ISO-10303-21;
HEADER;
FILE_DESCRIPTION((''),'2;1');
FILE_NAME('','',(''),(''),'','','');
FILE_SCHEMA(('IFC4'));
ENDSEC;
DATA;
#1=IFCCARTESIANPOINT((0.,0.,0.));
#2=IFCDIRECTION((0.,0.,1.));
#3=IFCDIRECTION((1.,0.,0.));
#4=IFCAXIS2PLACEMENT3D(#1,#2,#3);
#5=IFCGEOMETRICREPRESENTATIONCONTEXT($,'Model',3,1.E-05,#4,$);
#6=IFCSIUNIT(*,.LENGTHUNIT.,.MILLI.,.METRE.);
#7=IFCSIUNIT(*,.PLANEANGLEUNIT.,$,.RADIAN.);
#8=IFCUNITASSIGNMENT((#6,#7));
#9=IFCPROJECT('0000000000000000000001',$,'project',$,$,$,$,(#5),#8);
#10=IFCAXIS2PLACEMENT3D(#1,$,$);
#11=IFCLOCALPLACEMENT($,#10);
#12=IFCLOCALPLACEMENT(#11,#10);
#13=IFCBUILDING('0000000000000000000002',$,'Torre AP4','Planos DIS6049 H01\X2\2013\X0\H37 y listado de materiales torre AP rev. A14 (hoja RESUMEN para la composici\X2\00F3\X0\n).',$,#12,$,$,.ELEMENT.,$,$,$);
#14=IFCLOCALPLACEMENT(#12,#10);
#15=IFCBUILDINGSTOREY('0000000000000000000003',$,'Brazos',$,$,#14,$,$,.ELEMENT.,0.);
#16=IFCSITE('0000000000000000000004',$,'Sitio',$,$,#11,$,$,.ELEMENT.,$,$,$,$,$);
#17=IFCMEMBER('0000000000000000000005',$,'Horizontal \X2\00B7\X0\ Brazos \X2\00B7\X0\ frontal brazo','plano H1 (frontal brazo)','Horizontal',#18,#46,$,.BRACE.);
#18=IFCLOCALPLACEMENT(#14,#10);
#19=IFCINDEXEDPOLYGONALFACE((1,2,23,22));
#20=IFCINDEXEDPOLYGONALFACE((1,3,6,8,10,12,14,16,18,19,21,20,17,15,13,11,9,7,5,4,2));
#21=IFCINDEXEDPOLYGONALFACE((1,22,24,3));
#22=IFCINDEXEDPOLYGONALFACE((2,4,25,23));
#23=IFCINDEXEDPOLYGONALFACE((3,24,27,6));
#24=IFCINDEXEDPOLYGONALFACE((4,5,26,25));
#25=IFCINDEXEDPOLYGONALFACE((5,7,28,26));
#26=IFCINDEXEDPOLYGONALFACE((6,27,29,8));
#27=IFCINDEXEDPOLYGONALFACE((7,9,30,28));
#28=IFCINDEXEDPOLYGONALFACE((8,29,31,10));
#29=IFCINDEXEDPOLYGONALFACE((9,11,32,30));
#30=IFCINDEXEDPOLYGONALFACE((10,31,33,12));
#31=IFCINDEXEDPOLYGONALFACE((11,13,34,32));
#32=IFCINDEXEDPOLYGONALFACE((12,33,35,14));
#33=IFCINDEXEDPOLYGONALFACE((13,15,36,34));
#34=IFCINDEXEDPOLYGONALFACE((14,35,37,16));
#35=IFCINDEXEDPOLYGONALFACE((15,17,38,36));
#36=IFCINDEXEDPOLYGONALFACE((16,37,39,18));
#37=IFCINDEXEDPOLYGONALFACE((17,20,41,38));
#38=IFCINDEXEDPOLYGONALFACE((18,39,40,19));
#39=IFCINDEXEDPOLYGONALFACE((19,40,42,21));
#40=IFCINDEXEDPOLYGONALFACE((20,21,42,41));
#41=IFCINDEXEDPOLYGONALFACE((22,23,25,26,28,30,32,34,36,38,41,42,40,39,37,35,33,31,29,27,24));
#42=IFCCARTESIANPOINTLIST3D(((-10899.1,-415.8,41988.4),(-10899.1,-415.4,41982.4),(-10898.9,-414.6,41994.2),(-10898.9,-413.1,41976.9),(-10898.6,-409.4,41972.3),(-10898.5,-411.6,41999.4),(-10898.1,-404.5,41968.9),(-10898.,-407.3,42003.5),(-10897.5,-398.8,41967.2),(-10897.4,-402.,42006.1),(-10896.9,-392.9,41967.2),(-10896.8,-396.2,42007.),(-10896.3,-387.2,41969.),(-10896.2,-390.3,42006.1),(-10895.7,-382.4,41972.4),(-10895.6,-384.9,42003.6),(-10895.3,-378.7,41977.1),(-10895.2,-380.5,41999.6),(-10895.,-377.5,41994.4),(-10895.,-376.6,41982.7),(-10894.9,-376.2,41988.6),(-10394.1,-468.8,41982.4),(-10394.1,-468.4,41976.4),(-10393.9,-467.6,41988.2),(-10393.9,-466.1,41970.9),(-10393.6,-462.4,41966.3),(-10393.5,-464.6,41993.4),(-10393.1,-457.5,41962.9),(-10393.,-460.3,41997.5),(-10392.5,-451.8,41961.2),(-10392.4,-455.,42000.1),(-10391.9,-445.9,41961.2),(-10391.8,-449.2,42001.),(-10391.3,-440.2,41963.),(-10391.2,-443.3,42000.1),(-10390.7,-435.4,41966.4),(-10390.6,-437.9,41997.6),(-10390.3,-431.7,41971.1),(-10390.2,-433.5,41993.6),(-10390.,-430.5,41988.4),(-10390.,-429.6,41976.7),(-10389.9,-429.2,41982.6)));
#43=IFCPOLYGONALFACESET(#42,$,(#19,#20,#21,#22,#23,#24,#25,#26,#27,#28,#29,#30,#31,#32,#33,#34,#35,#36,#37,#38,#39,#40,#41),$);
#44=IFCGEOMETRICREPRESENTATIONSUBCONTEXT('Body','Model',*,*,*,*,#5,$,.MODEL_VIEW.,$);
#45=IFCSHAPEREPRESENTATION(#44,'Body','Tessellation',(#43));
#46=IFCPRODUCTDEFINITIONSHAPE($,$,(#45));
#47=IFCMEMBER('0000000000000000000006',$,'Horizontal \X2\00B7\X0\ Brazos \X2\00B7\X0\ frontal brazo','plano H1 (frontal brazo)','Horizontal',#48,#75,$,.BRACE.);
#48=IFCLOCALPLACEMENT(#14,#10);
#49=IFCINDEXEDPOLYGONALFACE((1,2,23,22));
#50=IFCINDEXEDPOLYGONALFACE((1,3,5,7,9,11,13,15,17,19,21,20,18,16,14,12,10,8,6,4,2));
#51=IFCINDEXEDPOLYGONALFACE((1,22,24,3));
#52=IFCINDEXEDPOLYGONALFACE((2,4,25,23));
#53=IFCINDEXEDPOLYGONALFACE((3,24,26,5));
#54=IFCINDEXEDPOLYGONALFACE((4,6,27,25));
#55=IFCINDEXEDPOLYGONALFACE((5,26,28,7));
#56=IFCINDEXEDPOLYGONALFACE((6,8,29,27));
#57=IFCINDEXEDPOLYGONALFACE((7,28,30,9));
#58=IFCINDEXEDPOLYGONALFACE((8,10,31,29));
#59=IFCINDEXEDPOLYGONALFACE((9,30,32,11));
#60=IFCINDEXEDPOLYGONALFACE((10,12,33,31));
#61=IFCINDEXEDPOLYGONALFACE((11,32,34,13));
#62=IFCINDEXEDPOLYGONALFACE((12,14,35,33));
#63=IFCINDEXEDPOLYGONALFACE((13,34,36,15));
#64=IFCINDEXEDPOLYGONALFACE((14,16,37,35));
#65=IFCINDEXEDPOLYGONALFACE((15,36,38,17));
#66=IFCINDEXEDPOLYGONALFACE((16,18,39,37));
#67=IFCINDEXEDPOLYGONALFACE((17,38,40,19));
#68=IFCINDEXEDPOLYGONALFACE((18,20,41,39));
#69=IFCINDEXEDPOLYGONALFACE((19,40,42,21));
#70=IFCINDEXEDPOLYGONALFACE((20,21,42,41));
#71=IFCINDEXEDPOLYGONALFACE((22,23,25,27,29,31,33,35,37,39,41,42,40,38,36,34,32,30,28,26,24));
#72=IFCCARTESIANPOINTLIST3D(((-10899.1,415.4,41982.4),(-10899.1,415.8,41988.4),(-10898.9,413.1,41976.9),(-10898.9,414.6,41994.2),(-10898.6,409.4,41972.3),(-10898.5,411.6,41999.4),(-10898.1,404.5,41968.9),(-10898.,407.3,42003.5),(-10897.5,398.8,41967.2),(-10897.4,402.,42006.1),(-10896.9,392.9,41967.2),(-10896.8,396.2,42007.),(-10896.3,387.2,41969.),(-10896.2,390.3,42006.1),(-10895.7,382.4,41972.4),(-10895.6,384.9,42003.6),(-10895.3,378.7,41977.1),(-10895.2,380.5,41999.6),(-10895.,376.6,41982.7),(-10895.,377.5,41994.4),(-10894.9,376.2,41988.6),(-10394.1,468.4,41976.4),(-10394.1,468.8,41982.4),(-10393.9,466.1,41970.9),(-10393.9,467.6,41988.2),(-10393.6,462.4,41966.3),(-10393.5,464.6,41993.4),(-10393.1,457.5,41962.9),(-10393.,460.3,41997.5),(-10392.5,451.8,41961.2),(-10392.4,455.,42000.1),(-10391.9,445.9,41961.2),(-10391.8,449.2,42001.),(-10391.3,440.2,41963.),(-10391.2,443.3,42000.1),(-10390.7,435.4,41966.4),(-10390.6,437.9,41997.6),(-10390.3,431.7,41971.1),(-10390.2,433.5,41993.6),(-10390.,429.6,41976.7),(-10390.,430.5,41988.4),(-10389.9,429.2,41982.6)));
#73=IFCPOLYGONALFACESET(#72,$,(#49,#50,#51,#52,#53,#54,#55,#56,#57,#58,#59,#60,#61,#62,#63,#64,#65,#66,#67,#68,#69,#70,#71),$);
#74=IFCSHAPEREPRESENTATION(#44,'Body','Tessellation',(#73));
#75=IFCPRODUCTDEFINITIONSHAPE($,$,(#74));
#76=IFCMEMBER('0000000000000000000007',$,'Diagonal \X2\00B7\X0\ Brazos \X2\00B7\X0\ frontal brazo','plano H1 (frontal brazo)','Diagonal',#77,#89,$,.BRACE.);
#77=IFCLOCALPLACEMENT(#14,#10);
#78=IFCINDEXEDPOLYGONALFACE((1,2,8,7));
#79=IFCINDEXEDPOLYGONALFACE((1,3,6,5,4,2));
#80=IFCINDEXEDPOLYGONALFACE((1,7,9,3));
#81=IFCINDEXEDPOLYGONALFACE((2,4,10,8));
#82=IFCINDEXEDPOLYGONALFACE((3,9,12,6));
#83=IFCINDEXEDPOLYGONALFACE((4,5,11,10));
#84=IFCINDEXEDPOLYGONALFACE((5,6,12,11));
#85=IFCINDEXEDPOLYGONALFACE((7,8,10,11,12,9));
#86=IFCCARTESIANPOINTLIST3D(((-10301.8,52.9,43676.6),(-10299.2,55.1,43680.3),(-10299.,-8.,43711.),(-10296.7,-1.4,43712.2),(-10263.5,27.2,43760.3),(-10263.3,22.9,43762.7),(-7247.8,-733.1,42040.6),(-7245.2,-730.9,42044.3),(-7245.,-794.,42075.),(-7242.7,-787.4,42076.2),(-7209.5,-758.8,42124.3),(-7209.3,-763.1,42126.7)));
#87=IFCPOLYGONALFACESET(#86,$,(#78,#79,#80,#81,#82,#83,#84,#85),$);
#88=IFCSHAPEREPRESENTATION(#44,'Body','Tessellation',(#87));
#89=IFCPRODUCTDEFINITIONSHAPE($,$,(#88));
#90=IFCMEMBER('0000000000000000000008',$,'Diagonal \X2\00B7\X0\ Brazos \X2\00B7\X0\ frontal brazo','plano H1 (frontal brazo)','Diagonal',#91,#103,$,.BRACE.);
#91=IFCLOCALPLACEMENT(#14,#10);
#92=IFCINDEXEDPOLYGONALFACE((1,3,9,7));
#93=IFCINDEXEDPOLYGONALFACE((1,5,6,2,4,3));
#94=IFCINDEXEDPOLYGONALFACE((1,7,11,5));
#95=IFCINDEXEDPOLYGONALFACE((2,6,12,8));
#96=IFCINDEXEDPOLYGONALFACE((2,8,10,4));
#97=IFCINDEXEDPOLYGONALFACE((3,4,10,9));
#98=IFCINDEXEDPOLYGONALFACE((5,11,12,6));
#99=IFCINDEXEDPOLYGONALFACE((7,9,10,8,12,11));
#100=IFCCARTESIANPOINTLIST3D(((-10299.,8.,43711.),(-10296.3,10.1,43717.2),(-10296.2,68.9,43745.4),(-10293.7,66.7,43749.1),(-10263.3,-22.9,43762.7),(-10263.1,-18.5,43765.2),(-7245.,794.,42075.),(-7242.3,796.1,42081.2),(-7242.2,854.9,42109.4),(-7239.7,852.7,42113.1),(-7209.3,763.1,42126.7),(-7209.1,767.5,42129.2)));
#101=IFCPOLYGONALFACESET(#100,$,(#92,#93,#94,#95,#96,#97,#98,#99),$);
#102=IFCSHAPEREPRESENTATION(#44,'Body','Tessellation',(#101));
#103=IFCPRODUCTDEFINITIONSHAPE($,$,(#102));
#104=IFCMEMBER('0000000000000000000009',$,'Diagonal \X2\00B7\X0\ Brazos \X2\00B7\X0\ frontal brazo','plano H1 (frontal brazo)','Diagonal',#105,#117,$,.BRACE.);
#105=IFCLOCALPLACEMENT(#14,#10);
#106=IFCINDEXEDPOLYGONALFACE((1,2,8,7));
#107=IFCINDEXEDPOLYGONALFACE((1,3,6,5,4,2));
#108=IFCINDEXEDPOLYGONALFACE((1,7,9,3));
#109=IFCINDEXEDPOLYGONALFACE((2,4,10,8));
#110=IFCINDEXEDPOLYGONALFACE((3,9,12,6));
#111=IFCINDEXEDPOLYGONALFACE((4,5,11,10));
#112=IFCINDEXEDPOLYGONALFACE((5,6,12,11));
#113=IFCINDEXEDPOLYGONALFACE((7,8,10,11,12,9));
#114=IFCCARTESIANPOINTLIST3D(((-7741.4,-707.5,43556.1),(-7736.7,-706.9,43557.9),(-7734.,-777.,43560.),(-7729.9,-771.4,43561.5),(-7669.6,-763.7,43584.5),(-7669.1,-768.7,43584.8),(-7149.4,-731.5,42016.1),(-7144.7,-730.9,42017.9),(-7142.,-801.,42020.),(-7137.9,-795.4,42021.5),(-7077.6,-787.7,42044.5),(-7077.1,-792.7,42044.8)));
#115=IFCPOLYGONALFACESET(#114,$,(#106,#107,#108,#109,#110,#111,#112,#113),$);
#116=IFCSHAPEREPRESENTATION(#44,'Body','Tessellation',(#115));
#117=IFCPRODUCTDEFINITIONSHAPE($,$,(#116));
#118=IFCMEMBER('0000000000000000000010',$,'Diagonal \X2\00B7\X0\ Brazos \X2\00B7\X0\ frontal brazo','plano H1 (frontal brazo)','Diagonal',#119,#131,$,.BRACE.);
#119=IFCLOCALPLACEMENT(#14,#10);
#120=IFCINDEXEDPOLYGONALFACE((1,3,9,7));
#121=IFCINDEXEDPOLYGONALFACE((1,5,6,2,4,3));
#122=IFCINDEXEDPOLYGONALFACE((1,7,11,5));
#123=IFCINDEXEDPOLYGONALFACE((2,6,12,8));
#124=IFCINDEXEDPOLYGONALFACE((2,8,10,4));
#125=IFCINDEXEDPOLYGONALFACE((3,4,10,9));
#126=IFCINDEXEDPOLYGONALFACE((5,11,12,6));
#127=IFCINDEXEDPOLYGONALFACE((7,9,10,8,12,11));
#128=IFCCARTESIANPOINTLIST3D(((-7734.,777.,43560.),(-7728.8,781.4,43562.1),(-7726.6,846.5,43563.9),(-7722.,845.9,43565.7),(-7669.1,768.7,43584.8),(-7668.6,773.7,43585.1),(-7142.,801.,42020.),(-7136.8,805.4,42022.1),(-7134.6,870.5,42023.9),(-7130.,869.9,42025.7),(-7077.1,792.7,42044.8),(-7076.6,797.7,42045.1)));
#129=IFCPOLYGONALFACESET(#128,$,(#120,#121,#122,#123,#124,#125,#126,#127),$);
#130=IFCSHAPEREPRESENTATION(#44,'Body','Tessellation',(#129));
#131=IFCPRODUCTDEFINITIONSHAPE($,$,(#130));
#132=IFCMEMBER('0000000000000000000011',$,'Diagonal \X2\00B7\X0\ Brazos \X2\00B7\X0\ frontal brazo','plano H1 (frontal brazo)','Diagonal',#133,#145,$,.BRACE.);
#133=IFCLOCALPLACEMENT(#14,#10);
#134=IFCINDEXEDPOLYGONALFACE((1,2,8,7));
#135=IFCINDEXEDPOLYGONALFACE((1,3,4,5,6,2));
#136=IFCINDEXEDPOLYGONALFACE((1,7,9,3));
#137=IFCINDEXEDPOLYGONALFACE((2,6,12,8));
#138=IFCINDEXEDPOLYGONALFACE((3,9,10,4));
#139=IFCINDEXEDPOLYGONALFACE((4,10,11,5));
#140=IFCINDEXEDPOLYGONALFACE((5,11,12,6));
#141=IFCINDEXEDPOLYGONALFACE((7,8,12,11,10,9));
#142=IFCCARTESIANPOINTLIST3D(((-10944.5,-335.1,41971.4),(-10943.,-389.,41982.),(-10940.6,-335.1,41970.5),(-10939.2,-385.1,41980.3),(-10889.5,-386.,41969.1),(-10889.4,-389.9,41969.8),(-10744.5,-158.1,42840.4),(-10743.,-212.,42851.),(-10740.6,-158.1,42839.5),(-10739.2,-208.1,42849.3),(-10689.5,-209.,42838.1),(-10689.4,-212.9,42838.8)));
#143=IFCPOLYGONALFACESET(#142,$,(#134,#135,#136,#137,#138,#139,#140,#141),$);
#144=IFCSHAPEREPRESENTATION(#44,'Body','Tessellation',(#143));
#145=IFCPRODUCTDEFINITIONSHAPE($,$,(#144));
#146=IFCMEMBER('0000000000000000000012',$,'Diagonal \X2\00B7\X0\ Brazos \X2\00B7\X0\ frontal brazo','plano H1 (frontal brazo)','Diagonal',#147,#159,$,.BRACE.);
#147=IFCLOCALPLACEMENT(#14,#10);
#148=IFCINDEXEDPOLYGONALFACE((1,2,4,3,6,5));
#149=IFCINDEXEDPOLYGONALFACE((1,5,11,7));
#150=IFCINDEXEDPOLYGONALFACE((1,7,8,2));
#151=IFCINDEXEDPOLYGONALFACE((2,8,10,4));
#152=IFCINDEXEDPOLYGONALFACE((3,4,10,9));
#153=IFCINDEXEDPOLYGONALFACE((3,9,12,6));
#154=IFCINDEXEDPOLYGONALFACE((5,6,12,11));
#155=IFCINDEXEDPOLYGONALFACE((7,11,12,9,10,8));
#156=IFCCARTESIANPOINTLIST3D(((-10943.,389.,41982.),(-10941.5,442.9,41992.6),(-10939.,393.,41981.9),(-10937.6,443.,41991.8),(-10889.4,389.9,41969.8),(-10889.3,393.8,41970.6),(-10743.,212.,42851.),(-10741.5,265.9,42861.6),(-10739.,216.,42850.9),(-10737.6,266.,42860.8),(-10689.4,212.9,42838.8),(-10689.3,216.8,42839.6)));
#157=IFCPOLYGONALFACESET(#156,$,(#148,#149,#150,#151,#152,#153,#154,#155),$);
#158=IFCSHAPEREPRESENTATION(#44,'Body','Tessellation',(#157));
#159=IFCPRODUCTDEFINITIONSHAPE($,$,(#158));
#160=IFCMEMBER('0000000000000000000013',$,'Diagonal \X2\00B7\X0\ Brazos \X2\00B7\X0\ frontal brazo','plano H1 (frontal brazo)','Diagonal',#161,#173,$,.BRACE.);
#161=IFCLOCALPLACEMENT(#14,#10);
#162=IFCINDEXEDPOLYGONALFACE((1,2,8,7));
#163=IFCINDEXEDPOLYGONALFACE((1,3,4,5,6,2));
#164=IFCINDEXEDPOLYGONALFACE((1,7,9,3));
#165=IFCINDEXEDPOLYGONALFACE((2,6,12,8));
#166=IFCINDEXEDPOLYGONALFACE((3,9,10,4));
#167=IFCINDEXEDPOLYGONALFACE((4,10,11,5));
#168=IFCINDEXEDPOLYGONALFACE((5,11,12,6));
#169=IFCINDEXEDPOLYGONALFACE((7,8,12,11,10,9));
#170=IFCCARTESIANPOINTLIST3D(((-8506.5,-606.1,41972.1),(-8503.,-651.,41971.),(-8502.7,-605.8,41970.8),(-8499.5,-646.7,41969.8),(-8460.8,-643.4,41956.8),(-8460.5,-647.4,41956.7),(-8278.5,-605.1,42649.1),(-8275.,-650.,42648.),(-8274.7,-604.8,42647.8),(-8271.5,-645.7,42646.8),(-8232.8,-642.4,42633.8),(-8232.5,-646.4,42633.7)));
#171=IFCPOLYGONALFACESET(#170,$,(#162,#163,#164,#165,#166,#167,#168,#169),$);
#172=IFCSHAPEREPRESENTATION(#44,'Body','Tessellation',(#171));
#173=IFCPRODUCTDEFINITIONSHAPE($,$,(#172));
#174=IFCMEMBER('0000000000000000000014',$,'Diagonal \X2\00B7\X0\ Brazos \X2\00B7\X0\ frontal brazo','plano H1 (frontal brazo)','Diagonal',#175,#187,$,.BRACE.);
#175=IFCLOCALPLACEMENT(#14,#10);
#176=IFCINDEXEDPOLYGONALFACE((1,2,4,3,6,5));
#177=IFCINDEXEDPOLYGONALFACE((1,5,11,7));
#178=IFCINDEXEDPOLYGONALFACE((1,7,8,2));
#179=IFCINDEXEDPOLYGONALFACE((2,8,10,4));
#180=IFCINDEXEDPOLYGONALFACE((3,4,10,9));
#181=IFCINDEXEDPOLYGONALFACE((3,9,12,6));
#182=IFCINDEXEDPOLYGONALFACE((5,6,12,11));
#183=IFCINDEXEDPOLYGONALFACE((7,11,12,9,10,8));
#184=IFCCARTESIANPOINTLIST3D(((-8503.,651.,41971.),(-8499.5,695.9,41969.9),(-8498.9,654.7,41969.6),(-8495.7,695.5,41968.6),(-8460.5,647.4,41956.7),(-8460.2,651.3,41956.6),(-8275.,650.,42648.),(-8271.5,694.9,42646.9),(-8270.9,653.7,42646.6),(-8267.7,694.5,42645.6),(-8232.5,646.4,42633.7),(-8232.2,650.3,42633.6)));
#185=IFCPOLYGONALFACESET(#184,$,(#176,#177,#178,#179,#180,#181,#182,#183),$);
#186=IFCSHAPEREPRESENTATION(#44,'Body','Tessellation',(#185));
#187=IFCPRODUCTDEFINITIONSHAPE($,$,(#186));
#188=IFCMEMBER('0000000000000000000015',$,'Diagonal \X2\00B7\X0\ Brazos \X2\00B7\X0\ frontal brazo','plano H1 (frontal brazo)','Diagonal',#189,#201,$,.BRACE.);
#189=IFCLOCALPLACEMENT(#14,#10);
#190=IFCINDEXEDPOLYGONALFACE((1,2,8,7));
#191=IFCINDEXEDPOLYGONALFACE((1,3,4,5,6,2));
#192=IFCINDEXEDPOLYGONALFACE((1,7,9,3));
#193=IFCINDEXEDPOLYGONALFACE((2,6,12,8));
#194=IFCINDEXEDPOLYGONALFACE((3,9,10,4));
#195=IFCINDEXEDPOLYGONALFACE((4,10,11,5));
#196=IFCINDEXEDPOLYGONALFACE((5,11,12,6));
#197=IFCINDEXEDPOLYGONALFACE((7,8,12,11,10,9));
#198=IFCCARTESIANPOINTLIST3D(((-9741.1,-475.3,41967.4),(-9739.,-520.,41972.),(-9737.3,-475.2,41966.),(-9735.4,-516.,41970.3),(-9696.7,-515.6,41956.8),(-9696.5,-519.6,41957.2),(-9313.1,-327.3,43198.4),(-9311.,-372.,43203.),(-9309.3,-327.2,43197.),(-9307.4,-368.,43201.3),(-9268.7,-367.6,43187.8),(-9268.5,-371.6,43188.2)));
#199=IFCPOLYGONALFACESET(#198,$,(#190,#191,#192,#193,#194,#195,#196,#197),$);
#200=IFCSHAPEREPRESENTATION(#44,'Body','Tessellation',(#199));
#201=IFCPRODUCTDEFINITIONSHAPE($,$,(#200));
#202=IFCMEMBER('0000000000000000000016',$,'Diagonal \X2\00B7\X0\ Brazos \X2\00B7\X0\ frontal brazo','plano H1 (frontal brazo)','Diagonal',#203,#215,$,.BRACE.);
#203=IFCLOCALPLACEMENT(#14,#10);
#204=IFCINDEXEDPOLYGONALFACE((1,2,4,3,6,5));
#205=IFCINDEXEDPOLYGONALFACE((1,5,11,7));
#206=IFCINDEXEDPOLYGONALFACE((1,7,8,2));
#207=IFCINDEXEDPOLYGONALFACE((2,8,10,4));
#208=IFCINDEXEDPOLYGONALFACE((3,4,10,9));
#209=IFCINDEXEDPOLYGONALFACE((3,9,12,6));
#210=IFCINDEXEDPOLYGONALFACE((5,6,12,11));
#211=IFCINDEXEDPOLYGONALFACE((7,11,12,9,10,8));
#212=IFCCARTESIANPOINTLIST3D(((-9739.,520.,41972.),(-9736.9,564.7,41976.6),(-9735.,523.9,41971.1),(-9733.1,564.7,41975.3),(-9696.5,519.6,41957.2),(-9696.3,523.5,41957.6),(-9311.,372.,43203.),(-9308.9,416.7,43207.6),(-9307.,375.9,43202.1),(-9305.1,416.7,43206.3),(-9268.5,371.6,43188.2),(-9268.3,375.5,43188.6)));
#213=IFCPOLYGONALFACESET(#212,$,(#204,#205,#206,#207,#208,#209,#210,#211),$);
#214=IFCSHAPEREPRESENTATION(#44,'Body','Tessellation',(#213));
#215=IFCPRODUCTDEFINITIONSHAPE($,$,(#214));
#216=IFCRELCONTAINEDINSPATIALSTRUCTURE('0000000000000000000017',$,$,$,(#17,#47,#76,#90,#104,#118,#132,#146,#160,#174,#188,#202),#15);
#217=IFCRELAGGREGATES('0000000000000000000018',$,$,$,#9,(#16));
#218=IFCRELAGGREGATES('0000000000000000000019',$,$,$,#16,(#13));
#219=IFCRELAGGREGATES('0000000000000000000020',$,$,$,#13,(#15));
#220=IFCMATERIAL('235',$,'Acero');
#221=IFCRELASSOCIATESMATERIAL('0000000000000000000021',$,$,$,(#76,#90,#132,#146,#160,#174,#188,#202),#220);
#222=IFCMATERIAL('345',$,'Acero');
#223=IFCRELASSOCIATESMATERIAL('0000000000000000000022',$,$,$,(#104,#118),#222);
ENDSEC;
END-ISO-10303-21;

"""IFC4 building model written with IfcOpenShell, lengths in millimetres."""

from ifc_helpers import new_model, si_unit, frame, frame_2d, origin, origin_with_axes, place, context, subcontext, project, spatial, circle, l_section, extrude, material, element, save


model = new_model("IFC4")

# Units and contexts
model_context = context("Model", 3, precision=1e-05, world=origin_with_axes())
body_context = subcontext(model_context, "Body", "Model", "MODEL_VIEW")
ifc_project = project(units=[si_unit("LENGTHUNIT", "METRE", prefix="MILLI"), si_unit("PLANEANGLEUNIT", "RADIAN")], contexts=[model_context])

# Site, building, storey
site_placement = place(None, origin())
site = spatial("IfcSite", under=ifc_project, at=site_placement, Name="Sitio", CompositionType="ELEMENT")
building_placement = place(site_placement, origin())
building = spatial("IfcBuilding", under=site, at=building_placement, Name="Torre AP4", Description="Planos DIS6049 H01–H37 y listado de materiales torre AP rev. A14 (hoja RESUMEN para la composición).", CompositionType="ELEMENT")
storey_placement = place(building_placement, origin())
storey = spatial("IfcBuildingStorey", under=building, at=storey_placement, Name="Brazos", CompositionType="ELEMENT", Elevation=0.0)

# Members
for number, where, z_axis, x_axis, name in (
    (1, (-10392.0, -449.0, 41981.0), (-0.994468, 0.10437, 0.011815), (0.104986, 0.991163, 0.081074), "Horizontal · Brazos · frontal brazo"),
    (2, (-10392.0, 449.0, 41981.0), (-0.994468, -0.10437, 0.011815), (0.104986, -0.991163, 0.081074), "Horizontal · Brazos · frontal brazo"),
):
    element("IfcMember", number, at=place(storey_placement, frame(where, z_axis=z_axis, x_axis=x_axis)), inside=storey, Name=name, Description="plano H1 (frontal brazo)", ObjectType="Horizontal", PredefinedType="BRACE", context=body_context, shape_type="SweptSolid", body=[
        extrude(circle(Radius=20.0), None, (0.0, 0.0, 1.0), 507.8),
    ])
ifc_material_1 = material(Name="235", Category="Acero")
for number, where, z_axis, x_axis, name in (
    (3, (-7245.0, -794.0, 42075.0), (-0.859644, 0.221244, 0.460503), (0.509345, 0.441284, 0.738808), "Diagonal · Brazos · frontal brazo"),
    (4, (-7245.0, 794.0, 42075.0), (-0.859644, -0.221244, 0.460503), (0.509345, -0.441284, 0.738808), "Diagonal · Brazos · frontal brazo"),
):
    element("IfcMember", number, at=place(storey_placement, frame(where, z_axis=z_axis, x_axis=x_axis)), inside=storey, material=ifc_material_1, Name=name, Description="plano H1 (frontal brazo)", ObjectType="Diagonal", PredefinedType="BRACE", context=body_context, shape_type="SweptSolid", body=[
        extrude(l_section(Depth=70.0, Width=70.0, Thickness=5.0, at=frame_2d((35.0, 35.0))), None, (0.0, 0.0, 1.0), 3552.6),
    ])
ifc_material_2 = material(Name="345", Category="Acero")
for number, where, z_axis, x_axis, name in (
    (5, (-7142.0, -801.0, 42020.0), (-0.358779, 0.014545, 0.933309), (0.927462, 0.118373, 0.354686), "Diagonal · Brazos · frontal brazo"),
    (6, (-7142.0, 801.0, 42020.0), (-0.358779, -0.014545, 0.933309), (0.927462, -0.118373, 0.354686), "Diagonal · Brazos · frontal brazo"),
):
    element("IfcMember", number, at=place(storey_placement, frame(where, z_axis=z_axis, x_axis=x_axis)), inside=storey, material=ifc_material_2, Name=name, Description="plano H1 (frontal brazo)", ObjectType="Diagonal", PredefinedType="BRACE", context=body_context, shape_type="SweptSolid", body=[
        extrude(l_section(Depth=70.0, Width=70.0, Thickness=5.0, at=frame_2d((35.0, 35.0))), None, (0.0, 0.0, 1.0), 1650.0),
    ])
for number, where, z_axis, x_axis, name in (
    (7, (-10943.0, -389.0, 41982.0), (0.219994, 0.194695, 0.955875), (0.975122, -0.016589, -0.221045), "Diagonal · Brazos · frontal brazo"),
    (8, (-10943.0, 389.0, 41982.0), (0.219994, -0.194695, 0.955875), (0.975122, 0.016589, -0.221045), "Diagonal · Brazos · frontal brazo"),
):
    element("IfcMember", number, at=place(storey_placement, frame(where, z_axis=z_axis, x_axis=x_axis)), inside=storey, material=ifc_material_1, Name=name, Description="plano H1 (frontal brazo)", ObjectType="Diagonal", PredefinedType="BRACE", context=body_context, shape_type="SweptSolid", body=[
        extrude(l_section(Depth=55.0, Width=55.0, Thickness=4.0, at=frame_2d((27.5, 27.5))), None, (0.0, 0.0, 1.0), 909.1),
    ])
for number, where, z_axis, x_axis, name in (
    (9, (-8503.0, -651.0, 41971.0), (0.319166, 0.0014, 0.947698), (0.944542, 0.081082, -0.318223), "Diagonal · Brazos · frontal brazo"),
    (10, (-8503.0, 651.0, 41971.0), (0.319166, -0.0014, 0.947698), (0.944542, -0.081082, -0.318223), "Diagonal · Brazos · frontal brazo"),
):
    element("IfcMember", number, at=place(storey_placement, frame(where, z_axis=z_axis, x_axis=x_axis)), inside=storey, material=ifc_material_1, Name=name, Description="plano H1 (frontal brazo)", ObjectType="Diagonal", PredefinedType="BRACE", context=body_context, shape_type="SweptSolid", body=[
        extrude(l_section(Depth=45.0, Width=45.0, Thickness=4.0, at=frame_2d((22.5, 22.5))), None, (0.0, 0.0, 1.0), 714.4),
    ])
for number, where, z_axis, x_axis, name in (
    (11, (-9739.0, -520.0, 41972.0), (0.326304, 0.112834, 0.938506), (0.944119, 0.009962, -0.329454), "Diagonal · Brazos · frontal brazo"),
    (12, (-9739.0, 520.0, 41972.0), (0.326304, -0.112834, 0.938506), (0.944119, -0.009962, -0.329454), "Diagonal · Brazos · frontal brazo"),
):
    element("IfcMember", number, at=place(storey_placement, frame(where, z_axis=z_axis, x_axis=x_axis)), inside=storey, material=ifc_material_1, Name=name, Description="plano H1 (frontal brazo)", ObjectType="Diagonal", PredefinedType="BRACE", context=body_context, shape_type="SweptSolid", body=[
        extrude(l_section(Depth=45.0, Width=45.0, Thickness=4.0, at=frame_2d((22.5, 22.5))), None, (0.0, 0.0, 1.0), 1311.7),
    ])

save(model, "model.ifc")
